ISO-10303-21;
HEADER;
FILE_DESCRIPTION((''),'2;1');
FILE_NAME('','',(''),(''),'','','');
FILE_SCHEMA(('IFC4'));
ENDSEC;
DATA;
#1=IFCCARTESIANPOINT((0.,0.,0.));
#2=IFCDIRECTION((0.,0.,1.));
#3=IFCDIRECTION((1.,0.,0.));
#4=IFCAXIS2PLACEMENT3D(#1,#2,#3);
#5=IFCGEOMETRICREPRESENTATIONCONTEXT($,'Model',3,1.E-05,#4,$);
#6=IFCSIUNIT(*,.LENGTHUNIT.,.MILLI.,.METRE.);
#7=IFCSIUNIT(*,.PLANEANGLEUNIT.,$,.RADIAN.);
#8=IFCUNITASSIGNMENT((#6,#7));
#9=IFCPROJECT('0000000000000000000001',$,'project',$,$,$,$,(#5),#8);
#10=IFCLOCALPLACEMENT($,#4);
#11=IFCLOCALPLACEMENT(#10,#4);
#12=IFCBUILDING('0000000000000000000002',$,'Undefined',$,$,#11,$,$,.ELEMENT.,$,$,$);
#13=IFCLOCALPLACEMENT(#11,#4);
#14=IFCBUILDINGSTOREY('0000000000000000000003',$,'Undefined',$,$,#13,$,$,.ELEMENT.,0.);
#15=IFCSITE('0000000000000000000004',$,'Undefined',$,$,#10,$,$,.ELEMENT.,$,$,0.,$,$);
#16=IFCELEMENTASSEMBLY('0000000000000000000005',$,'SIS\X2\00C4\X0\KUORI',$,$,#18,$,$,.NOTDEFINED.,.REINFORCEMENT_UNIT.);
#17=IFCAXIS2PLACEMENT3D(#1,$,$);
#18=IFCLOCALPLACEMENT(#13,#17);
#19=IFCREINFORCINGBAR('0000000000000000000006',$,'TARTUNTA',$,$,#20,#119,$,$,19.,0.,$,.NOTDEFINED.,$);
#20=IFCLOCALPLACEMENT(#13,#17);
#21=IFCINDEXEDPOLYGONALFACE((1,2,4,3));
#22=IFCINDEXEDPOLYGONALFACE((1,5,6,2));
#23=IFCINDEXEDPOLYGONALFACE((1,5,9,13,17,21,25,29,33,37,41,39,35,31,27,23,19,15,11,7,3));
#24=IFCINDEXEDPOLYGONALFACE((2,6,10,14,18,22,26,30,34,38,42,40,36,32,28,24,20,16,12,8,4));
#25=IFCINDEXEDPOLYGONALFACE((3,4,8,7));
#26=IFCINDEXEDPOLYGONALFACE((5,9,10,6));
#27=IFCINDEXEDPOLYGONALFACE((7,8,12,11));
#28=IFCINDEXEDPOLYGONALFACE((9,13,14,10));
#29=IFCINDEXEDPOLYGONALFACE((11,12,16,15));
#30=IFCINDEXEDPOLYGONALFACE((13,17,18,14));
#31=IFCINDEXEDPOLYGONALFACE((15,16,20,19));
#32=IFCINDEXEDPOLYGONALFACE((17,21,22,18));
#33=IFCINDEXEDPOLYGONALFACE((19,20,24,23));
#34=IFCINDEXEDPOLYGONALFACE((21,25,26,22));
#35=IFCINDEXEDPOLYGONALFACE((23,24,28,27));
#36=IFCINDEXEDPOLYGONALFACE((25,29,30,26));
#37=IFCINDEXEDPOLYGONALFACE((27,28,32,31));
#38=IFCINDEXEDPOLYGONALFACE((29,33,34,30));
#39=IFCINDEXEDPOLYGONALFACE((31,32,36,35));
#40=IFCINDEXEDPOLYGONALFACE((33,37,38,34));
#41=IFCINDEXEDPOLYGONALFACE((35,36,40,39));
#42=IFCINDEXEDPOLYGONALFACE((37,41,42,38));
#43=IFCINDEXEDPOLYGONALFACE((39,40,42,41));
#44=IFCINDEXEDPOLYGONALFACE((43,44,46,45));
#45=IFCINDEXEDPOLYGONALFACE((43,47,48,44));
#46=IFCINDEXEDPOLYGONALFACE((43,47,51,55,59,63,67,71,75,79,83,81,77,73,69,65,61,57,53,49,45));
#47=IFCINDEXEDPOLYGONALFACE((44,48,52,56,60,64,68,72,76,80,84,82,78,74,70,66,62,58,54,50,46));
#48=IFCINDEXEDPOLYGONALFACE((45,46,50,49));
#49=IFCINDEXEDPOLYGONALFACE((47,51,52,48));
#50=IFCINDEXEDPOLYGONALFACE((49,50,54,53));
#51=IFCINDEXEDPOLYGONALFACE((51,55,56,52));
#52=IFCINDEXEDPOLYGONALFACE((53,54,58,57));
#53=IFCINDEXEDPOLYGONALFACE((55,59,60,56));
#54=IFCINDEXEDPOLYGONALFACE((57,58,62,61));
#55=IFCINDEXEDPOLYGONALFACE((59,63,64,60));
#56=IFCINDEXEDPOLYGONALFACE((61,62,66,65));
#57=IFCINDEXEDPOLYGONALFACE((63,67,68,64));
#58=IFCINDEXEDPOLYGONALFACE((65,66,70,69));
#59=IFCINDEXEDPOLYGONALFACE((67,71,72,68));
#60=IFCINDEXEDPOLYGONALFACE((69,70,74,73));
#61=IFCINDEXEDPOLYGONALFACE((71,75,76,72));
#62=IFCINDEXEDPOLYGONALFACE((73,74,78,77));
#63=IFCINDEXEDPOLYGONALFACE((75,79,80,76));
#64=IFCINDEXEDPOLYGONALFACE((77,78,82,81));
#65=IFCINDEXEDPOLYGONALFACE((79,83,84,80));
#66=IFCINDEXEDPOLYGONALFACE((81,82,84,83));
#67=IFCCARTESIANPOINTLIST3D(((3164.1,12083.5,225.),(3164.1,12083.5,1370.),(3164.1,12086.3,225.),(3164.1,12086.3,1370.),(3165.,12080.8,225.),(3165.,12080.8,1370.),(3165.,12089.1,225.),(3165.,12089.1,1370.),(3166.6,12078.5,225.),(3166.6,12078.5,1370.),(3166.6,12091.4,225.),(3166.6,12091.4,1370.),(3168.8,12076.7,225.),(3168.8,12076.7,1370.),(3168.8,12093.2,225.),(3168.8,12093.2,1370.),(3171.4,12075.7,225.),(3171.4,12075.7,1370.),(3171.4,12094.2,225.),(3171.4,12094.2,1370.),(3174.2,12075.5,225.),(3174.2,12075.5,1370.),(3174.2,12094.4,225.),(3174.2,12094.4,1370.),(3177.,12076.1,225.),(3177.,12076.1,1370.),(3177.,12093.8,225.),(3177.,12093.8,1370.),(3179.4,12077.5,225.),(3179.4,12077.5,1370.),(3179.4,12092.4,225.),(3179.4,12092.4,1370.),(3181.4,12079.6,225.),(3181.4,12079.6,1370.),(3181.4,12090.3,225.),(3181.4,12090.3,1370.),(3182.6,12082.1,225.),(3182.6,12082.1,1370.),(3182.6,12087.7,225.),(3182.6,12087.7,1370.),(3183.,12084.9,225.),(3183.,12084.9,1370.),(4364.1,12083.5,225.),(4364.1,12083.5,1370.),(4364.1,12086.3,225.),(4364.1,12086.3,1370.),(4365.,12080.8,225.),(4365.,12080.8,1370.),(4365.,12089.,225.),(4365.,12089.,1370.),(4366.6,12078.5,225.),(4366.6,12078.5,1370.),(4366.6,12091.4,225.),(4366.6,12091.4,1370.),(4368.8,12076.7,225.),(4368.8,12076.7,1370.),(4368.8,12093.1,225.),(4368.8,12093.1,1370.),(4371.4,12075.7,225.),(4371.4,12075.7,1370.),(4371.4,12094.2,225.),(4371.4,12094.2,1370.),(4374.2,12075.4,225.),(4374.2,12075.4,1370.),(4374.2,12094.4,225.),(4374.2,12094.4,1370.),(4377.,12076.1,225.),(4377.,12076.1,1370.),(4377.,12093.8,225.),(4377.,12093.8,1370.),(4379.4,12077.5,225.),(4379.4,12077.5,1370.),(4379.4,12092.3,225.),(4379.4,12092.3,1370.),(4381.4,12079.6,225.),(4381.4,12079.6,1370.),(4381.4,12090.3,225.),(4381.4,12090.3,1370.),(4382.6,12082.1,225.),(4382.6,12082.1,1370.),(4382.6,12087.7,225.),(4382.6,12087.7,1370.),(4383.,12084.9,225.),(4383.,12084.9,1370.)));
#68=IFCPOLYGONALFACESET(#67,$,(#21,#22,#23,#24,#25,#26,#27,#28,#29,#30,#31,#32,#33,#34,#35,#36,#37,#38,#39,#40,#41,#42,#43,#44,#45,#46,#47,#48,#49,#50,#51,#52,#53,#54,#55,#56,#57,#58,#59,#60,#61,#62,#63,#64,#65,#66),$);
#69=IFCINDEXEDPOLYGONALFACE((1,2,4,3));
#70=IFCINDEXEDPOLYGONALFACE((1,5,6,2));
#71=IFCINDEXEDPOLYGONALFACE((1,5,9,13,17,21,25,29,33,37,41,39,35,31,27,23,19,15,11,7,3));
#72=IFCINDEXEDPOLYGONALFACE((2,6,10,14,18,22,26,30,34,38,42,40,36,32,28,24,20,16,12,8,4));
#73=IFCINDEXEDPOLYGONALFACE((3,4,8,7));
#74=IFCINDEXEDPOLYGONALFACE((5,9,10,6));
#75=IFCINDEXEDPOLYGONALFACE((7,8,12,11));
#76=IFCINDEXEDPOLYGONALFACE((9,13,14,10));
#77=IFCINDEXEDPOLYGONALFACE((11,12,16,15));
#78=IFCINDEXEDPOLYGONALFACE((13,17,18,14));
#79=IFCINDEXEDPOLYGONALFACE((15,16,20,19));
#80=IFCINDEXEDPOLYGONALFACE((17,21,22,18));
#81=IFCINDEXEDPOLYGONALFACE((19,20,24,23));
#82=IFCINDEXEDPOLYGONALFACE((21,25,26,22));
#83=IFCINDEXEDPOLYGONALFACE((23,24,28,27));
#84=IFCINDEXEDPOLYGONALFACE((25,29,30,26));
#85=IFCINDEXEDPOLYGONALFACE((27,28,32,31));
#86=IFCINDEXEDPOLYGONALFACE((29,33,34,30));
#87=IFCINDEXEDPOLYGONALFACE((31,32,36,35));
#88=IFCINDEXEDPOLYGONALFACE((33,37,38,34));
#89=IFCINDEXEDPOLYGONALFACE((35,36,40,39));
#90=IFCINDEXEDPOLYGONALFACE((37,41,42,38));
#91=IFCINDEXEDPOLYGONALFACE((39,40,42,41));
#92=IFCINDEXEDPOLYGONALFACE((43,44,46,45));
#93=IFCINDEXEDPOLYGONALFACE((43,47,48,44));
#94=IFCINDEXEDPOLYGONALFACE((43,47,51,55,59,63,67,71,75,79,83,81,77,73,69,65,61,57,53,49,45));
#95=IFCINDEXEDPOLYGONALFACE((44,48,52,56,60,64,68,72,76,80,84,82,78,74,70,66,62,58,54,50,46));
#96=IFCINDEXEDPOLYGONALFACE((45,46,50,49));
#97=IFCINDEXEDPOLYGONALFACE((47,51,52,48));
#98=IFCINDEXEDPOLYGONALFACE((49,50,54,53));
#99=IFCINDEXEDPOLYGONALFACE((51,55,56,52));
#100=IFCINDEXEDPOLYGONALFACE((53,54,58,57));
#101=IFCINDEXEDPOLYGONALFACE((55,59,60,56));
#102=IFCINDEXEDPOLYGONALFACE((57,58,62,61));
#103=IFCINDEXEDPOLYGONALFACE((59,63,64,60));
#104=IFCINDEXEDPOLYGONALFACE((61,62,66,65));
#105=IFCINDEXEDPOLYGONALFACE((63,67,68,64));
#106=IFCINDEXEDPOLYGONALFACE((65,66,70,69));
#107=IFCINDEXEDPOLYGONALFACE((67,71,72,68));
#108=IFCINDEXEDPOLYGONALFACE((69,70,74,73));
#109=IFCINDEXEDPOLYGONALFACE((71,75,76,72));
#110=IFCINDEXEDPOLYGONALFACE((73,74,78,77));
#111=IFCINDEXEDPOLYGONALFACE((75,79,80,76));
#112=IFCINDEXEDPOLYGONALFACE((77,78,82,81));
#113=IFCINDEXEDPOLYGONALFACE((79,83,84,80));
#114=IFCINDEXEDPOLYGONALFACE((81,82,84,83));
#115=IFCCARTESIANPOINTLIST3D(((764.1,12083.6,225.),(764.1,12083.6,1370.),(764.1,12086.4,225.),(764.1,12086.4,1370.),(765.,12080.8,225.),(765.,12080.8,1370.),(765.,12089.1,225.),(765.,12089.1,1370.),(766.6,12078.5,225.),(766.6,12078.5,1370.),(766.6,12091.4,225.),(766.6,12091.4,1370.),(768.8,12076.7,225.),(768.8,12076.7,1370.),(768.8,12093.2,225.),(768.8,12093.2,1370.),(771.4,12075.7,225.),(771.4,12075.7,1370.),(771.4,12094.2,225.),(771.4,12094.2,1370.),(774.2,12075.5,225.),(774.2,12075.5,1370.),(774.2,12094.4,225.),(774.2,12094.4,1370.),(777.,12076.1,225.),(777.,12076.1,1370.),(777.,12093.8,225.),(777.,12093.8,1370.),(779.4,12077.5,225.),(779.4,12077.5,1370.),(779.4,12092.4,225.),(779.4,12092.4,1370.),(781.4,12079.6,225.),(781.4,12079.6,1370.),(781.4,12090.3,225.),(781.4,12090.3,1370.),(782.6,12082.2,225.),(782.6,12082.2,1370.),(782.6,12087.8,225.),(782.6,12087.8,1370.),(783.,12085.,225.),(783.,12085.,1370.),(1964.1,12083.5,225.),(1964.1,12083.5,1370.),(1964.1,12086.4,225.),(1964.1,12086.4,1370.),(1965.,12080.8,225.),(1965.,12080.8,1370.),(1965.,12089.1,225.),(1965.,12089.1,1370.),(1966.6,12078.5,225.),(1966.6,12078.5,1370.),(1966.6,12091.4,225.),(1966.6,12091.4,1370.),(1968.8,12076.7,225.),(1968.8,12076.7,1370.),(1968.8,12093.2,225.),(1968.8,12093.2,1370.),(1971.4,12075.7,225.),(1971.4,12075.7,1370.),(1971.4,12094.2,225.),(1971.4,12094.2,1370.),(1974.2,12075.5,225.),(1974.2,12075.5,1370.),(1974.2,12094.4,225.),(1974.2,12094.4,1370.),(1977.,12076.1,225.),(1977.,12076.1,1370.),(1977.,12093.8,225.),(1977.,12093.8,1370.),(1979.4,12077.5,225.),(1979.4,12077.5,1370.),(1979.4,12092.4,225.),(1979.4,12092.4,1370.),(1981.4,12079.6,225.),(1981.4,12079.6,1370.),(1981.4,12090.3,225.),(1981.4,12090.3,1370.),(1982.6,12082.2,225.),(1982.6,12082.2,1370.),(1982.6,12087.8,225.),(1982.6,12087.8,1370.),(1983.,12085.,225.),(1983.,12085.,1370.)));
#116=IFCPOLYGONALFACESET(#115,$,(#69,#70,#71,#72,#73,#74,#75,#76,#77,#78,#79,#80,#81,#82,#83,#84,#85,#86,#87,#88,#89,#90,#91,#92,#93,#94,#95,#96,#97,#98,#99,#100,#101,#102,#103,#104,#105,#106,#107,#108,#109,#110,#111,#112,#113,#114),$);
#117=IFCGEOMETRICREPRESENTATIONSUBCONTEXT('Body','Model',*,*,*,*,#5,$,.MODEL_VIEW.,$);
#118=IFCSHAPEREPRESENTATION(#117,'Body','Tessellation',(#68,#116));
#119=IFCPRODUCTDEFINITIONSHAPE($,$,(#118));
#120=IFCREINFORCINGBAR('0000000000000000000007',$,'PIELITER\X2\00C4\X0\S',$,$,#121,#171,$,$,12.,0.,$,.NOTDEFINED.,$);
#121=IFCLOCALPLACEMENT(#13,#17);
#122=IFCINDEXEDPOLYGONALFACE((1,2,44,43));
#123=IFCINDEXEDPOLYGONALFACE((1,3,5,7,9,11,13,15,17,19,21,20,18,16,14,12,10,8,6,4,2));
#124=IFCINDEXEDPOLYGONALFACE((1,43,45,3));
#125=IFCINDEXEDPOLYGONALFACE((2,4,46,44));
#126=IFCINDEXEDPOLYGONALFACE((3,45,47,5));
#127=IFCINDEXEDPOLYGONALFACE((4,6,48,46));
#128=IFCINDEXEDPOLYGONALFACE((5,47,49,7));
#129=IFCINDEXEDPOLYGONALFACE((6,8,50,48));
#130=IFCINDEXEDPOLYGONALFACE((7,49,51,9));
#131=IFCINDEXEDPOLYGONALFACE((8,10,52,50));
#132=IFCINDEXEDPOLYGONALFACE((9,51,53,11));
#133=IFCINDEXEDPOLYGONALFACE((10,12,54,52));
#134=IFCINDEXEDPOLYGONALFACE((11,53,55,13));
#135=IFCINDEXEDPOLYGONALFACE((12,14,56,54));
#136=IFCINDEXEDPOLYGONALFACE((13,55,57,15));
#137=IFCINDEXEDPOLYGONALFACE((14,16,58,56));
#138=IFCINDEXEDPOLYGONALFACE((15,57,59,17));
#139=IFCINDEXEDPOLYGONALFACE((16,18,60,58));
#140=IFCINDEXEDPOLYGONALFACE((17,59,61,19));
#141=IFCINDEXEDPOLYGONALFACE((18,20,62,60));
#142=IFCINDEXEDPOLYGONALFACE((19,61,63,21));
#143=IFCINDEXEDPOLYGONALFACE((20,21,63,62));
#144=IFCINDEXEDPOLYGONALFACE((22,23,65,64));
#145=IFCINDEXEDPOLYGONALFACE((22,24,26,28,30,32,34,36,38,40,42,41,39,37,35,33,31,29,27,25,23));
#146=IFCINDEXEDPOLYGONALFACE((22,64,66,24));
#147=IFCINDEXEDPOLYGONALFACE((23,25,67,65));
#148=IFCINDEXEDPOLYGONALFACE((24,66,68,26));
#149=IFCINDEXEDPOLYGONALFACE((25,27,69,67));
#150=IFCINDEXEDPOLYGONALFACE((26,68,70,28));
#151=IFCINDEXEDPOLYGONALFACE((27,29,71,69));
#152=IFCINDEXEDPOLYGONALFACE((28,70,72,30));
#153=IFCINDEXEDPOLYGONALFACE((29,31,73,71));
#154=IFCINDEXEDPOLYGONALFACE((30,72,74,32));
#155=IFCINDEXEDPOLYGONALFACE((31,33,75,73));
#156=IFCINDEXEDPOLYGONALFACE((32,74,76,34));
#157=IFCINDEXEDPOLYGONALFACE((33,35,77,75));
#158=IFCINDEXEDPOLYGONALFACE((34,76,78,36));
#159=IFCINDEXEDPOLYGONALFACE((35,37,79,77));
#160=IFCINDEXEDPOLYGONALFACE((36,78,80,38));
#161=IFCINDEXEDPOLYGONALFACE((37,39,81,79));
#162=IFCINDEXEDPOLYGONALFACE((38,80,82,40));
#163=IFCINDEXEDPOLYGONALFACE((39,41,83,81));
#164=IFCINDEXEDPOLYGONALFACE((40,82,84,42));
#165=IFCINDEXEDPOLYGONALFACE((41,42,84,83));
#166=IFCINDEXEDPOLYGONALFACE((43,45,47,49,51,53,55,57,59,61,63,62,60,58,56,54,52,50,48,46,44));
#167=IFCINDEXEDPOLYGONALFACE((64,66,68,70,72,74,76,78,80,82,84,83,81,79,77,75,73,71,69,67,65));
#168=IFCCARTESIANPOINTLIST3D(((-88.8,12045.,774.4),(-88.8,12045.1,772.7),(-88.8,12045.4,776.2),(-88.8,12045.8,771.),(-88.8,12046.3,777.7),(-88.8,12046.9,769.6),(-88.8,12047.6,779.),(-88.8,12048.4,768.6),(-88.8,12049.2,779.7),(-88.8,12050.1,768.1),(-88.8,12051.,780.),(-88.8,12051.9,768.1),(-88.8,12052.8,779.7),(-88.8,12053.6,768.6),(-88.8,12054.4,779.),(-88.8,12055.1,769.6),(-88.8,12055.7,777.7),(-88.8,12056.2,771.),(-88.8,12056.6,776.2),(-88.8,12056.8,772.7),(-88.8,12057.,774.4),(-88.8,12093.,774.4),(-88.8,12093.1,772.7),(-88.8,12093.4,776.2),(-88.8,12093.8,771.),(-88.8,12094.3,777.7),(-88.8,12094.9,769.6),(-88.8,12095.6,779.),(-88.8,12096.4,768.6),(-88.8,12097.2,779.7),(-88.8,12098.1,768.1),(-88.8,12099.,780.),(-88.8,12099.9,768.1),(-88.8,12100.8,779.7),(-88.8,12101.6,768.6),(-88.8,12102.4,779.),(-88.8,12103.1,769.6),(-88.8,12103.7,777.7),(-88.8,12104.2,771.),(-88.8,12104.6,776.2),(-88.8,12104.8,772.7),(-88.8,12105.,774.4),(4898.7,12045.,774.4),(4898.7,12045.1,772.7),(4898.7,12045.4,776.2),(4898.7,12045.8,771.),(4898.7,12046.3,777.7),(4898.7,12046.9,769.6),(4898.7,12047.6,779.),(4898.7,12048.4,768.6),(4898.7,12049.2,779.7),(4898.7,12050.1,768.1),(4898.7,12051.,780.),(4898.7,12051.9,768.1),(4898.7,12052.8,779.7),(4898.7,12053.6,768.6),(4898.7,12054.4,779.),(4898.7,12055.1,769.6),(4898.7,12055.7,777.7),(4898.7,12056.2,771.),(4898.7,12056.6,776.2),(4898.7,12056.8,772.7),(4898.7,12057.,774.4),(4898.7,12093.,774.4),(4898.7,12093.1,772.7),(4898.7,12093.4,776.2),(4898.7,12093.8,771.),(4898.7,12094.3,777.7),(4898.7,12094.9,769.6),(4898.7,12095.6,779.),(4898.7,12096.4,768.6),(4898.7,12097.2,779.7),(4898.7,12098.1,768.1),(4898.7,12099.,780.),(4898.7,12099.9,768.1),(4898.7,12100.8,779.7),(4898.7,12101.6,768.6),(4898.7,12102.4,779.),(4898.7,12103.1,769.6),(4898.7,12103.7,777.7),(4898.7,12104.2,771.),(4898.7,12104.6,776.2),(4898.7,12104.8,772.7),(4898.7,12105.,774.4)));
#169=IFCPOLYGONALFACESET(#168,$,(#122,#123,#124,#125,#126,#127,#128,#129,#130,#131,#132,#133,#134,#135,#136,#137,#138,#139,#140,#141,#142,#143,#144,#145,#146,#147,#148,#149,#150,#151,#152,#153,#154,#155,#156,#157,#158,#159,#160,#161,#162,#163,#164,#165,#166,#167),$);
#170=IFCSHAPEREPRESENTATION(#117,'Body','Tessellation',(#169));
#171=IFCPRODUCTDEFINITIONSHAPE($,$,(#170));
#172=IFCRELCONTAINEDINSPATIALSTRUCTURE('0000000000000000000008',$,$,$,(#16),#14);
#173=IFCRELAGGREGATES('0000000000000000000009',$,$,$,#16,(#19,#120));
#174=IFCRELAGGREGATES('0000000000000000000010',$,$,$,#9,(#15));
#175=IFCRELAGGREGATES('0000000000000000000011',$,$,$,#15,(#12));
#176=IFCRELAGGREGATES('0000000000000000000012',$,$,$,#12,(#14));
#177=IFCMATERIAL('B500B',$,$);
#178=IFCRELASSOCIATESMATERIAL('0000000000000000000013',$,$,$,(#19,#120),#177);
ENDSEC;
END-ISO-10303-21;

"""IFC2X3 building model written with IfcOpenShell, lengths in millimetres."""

from ifc_helpers import new_model, entity, si_unit, frame, origin_with_axes, place, context, subcontext, project, spatial, source, transform, mapped, material, element, aggregate, save


model = new_model("IFC2X3")

# Units and contexts
model_context = context("Model", 3, precision=1e-05, world=origin_with_axes())
body_context = subcontext(model_context, "Body", "Model", "MODEL_VIEW")
ifc_project = project(units=[si_unit("LENGTHUNIT", "METRE", prefix="MILLI"), si_unit("PLANEANGLEUNIT", "RADIAN")], contexts=[model_context])

# Site, building, storey
site_placement = place(None, origin_with_axes())
site = spatial("IfcSite", under=ifc_project, at=site_placement, Name="Undefined", CompositionType="ELEMENT", RefElevation=0.0)
building_placement = place(site_placement, origin_with_axes())
building = spatial("IfcBuilding", under=site, at=building_placement, Name="Undefined", CompositionType="ELEMENT")
storey_placement = place(building_placement, origin_with_axes())
storey = spatial("IfcBuildingStorey", under=building, at=storey_placement, Name="Undefined", CompositionType="ELEMENT", Elevation=0.0)

# Element assembly
assembly_1_placement = place(storey_placement, origin_with_axes())
assembly_1 = element("IfcElementAssembly", 1, at=assembly_1_placement, inside=storey, Name="SISÄKUORI", AssemblyPlace="NOTDEFINED", PredefinedType="REINFORCEMENT_UNIT")

# Reinforcing bars
ifc_material_1 = material(Name="B500B")
shared_shape_1 = source(origin_with_axes(), body_context, "Body", "AdvancedSweptSolid", [
    entity("IfcSweptDiskSolid", entity("IfcTrimmedCurve", entity("IfcLine", entity("IfcCartesianPoint", [0.0, 0.0, 0.0]), entity("IfcVector", entity("IfcDirection", [1.0, 0.0, 0.0]), 1.0)), [entity("IfcParameterValue", 0.0)], [entity("IfcParameterValue", 1145.0)], True, "PARAMETER"), 9.5, None, 0.0, 1145.0),
])
shared_shape_2 = source(origin_with_axes(), body_context, "Body", "AdvancedSweptSolid", [
    entity("IfcSweptDiskSolid", entity("IfcTrimmedCurve", entity("IfcLine", entity("IfcCartesianPoint", [0.0, 0.0, 0.0]), entity("IfcVector", entity("IfcDirection", [1.0, 0.0, 0.0]), 1.0)), [entity("IfcParameterValue", 0.0)], [entity("IfcParameterValue", 1145.0)], True, "PARAMETER"), 9.5, None, 0.0, 1145.0),
])
shared_shape_3 = source(origin_with_axes(), body_context, "Body", "AdvancedSweptSolid", [
    entity("IfcSweptDiskSolid", entity("IfcTrimmedCurve", entity("IfcLine", entity("IfcCartesianPoint", [0.0, 0.0, 0.0]), entity("IfcVector", entity("IfcDirection", [1.0, 0.0, 0.0]), 1.0)), [entity("IfcParameterValue", 0.0)], [entity("IfcParameterValue", 1145.0)], True, "PARAMETER"), 9.5, None, 0.0, 1145.0),
])
shared_shape_4 = source(origin_with_axes(), body_context, "Body", "AdvancedSweptSolid", [
    entity("IfcSweptDiskSolid", entity("IfcTrimmedCurve", entity("IfcLine", entity("IfcCartesianPoint", [0.0, 0.0, 0.0]), entity("IfcVector", entity("IfcDirection", [1.0, 0.0, 0.0]), 1.0)), [entity("IfcParameterValue", 0.0)], [entity("IfcParameterValue", 1145.0)], True, "PARAMETER"), 9.5, None, 0.0, 1145.0),
])
reinforcing_bar_1_placement = place(assembly_1_placement, frame((4373.5, 12084.9, 225.0), z_axis=(1.0, 0.000008, 0.0), x_axis=(0.0, 0.0, 1.0)))
reinforcing_bar_1 = element("IfcReinforcingBar", 2, at=reinforcing_bar_1_placement, material=ifc_material_1, Name="TARTUNTA", BarRole="NOTDEFINED", CrossSectionArea=0.0, NominalDiameter=19.0, context=body_context, shape_type="MappedRepresentation", body=[
    mapped(shared_shape_1, transform((0.0, 0.0, 0.0))),
    mapped(shared_shape_2, transform((0.0, 0.0, -1200.0))),
    mapped(shared_shape_3, transform((0.0, -0.1, -2400.0))),
    mapped(shared_shape_4, transform((0.0, -0.1, -3600.0))),
])
shared_shape_5 = source(origin_with_axes(), body_context, "Body", "AdvancedSweptSolid", [
    entity("IfcSweptDiskSolid", entity("IfcTrimmedCurve", entity("IfcLine", entity("IfcCartesianPoint", [0.0, 0.0, 0.0]), entity("IfcVector", entity("IfcDirection", [1.0, 0.0, 0.0]), 1.0)), [entity("IfcParameterValue", 0.0)], [entity("IfcParameterValue", 4987.47882)], True, "PARAMETER"), 6.0, None, 0.0, 4987.5),
])
shared_shape_6 = source(origin_with_axes(), body_context, "Body", "AdvancedSweptSolid", [
    entity("IfcSweptDiskSolid", entity("IfcTrimmedCurve", entity("IfcLine", entity("IfcCartesianPoint", [0.0, 0.0, 0.0]), entity("IfcVector", entity("IfcDirection", [1.0, 0.0, 0.0]), 1.0)), [entity("IfcParameterValue", 0.0)], [entity("IfcParameterValue", 4987.47882)], True, "PARAMETER"), 6.0, None, 0.0, 4987.5),
])
reinforcing_bar_2_placement = place(assembly_1_placement, frame((4898.7, 12099.0, 774.0), z_axis=(0.0, 0.0, 1.0), x_axis=(-1.0, 0.0, 0.0)))
reinforcing_bar_2 = element("IfcReinforcingBar", 3, at=reinforcing_bar_2_placement, material=ifc_material_1, Name="PIELITERÄS", BarRole="NOTDEFINED", CrossSectionArea=0.0, NominalDiameter=12.0, context=body_context, shape_type="MappedRepresentation", body=[
    mapped(shared_shape_5, transform((0.0, 0.0, 0.0))),
    mapped(shared_shape_6, transform((0.0, 48.0, 0.0))),
])
aggregate(assembly_1, [reinforcing_bar_1, reinforcing_bar_2])

save(model, "model.ifc")
